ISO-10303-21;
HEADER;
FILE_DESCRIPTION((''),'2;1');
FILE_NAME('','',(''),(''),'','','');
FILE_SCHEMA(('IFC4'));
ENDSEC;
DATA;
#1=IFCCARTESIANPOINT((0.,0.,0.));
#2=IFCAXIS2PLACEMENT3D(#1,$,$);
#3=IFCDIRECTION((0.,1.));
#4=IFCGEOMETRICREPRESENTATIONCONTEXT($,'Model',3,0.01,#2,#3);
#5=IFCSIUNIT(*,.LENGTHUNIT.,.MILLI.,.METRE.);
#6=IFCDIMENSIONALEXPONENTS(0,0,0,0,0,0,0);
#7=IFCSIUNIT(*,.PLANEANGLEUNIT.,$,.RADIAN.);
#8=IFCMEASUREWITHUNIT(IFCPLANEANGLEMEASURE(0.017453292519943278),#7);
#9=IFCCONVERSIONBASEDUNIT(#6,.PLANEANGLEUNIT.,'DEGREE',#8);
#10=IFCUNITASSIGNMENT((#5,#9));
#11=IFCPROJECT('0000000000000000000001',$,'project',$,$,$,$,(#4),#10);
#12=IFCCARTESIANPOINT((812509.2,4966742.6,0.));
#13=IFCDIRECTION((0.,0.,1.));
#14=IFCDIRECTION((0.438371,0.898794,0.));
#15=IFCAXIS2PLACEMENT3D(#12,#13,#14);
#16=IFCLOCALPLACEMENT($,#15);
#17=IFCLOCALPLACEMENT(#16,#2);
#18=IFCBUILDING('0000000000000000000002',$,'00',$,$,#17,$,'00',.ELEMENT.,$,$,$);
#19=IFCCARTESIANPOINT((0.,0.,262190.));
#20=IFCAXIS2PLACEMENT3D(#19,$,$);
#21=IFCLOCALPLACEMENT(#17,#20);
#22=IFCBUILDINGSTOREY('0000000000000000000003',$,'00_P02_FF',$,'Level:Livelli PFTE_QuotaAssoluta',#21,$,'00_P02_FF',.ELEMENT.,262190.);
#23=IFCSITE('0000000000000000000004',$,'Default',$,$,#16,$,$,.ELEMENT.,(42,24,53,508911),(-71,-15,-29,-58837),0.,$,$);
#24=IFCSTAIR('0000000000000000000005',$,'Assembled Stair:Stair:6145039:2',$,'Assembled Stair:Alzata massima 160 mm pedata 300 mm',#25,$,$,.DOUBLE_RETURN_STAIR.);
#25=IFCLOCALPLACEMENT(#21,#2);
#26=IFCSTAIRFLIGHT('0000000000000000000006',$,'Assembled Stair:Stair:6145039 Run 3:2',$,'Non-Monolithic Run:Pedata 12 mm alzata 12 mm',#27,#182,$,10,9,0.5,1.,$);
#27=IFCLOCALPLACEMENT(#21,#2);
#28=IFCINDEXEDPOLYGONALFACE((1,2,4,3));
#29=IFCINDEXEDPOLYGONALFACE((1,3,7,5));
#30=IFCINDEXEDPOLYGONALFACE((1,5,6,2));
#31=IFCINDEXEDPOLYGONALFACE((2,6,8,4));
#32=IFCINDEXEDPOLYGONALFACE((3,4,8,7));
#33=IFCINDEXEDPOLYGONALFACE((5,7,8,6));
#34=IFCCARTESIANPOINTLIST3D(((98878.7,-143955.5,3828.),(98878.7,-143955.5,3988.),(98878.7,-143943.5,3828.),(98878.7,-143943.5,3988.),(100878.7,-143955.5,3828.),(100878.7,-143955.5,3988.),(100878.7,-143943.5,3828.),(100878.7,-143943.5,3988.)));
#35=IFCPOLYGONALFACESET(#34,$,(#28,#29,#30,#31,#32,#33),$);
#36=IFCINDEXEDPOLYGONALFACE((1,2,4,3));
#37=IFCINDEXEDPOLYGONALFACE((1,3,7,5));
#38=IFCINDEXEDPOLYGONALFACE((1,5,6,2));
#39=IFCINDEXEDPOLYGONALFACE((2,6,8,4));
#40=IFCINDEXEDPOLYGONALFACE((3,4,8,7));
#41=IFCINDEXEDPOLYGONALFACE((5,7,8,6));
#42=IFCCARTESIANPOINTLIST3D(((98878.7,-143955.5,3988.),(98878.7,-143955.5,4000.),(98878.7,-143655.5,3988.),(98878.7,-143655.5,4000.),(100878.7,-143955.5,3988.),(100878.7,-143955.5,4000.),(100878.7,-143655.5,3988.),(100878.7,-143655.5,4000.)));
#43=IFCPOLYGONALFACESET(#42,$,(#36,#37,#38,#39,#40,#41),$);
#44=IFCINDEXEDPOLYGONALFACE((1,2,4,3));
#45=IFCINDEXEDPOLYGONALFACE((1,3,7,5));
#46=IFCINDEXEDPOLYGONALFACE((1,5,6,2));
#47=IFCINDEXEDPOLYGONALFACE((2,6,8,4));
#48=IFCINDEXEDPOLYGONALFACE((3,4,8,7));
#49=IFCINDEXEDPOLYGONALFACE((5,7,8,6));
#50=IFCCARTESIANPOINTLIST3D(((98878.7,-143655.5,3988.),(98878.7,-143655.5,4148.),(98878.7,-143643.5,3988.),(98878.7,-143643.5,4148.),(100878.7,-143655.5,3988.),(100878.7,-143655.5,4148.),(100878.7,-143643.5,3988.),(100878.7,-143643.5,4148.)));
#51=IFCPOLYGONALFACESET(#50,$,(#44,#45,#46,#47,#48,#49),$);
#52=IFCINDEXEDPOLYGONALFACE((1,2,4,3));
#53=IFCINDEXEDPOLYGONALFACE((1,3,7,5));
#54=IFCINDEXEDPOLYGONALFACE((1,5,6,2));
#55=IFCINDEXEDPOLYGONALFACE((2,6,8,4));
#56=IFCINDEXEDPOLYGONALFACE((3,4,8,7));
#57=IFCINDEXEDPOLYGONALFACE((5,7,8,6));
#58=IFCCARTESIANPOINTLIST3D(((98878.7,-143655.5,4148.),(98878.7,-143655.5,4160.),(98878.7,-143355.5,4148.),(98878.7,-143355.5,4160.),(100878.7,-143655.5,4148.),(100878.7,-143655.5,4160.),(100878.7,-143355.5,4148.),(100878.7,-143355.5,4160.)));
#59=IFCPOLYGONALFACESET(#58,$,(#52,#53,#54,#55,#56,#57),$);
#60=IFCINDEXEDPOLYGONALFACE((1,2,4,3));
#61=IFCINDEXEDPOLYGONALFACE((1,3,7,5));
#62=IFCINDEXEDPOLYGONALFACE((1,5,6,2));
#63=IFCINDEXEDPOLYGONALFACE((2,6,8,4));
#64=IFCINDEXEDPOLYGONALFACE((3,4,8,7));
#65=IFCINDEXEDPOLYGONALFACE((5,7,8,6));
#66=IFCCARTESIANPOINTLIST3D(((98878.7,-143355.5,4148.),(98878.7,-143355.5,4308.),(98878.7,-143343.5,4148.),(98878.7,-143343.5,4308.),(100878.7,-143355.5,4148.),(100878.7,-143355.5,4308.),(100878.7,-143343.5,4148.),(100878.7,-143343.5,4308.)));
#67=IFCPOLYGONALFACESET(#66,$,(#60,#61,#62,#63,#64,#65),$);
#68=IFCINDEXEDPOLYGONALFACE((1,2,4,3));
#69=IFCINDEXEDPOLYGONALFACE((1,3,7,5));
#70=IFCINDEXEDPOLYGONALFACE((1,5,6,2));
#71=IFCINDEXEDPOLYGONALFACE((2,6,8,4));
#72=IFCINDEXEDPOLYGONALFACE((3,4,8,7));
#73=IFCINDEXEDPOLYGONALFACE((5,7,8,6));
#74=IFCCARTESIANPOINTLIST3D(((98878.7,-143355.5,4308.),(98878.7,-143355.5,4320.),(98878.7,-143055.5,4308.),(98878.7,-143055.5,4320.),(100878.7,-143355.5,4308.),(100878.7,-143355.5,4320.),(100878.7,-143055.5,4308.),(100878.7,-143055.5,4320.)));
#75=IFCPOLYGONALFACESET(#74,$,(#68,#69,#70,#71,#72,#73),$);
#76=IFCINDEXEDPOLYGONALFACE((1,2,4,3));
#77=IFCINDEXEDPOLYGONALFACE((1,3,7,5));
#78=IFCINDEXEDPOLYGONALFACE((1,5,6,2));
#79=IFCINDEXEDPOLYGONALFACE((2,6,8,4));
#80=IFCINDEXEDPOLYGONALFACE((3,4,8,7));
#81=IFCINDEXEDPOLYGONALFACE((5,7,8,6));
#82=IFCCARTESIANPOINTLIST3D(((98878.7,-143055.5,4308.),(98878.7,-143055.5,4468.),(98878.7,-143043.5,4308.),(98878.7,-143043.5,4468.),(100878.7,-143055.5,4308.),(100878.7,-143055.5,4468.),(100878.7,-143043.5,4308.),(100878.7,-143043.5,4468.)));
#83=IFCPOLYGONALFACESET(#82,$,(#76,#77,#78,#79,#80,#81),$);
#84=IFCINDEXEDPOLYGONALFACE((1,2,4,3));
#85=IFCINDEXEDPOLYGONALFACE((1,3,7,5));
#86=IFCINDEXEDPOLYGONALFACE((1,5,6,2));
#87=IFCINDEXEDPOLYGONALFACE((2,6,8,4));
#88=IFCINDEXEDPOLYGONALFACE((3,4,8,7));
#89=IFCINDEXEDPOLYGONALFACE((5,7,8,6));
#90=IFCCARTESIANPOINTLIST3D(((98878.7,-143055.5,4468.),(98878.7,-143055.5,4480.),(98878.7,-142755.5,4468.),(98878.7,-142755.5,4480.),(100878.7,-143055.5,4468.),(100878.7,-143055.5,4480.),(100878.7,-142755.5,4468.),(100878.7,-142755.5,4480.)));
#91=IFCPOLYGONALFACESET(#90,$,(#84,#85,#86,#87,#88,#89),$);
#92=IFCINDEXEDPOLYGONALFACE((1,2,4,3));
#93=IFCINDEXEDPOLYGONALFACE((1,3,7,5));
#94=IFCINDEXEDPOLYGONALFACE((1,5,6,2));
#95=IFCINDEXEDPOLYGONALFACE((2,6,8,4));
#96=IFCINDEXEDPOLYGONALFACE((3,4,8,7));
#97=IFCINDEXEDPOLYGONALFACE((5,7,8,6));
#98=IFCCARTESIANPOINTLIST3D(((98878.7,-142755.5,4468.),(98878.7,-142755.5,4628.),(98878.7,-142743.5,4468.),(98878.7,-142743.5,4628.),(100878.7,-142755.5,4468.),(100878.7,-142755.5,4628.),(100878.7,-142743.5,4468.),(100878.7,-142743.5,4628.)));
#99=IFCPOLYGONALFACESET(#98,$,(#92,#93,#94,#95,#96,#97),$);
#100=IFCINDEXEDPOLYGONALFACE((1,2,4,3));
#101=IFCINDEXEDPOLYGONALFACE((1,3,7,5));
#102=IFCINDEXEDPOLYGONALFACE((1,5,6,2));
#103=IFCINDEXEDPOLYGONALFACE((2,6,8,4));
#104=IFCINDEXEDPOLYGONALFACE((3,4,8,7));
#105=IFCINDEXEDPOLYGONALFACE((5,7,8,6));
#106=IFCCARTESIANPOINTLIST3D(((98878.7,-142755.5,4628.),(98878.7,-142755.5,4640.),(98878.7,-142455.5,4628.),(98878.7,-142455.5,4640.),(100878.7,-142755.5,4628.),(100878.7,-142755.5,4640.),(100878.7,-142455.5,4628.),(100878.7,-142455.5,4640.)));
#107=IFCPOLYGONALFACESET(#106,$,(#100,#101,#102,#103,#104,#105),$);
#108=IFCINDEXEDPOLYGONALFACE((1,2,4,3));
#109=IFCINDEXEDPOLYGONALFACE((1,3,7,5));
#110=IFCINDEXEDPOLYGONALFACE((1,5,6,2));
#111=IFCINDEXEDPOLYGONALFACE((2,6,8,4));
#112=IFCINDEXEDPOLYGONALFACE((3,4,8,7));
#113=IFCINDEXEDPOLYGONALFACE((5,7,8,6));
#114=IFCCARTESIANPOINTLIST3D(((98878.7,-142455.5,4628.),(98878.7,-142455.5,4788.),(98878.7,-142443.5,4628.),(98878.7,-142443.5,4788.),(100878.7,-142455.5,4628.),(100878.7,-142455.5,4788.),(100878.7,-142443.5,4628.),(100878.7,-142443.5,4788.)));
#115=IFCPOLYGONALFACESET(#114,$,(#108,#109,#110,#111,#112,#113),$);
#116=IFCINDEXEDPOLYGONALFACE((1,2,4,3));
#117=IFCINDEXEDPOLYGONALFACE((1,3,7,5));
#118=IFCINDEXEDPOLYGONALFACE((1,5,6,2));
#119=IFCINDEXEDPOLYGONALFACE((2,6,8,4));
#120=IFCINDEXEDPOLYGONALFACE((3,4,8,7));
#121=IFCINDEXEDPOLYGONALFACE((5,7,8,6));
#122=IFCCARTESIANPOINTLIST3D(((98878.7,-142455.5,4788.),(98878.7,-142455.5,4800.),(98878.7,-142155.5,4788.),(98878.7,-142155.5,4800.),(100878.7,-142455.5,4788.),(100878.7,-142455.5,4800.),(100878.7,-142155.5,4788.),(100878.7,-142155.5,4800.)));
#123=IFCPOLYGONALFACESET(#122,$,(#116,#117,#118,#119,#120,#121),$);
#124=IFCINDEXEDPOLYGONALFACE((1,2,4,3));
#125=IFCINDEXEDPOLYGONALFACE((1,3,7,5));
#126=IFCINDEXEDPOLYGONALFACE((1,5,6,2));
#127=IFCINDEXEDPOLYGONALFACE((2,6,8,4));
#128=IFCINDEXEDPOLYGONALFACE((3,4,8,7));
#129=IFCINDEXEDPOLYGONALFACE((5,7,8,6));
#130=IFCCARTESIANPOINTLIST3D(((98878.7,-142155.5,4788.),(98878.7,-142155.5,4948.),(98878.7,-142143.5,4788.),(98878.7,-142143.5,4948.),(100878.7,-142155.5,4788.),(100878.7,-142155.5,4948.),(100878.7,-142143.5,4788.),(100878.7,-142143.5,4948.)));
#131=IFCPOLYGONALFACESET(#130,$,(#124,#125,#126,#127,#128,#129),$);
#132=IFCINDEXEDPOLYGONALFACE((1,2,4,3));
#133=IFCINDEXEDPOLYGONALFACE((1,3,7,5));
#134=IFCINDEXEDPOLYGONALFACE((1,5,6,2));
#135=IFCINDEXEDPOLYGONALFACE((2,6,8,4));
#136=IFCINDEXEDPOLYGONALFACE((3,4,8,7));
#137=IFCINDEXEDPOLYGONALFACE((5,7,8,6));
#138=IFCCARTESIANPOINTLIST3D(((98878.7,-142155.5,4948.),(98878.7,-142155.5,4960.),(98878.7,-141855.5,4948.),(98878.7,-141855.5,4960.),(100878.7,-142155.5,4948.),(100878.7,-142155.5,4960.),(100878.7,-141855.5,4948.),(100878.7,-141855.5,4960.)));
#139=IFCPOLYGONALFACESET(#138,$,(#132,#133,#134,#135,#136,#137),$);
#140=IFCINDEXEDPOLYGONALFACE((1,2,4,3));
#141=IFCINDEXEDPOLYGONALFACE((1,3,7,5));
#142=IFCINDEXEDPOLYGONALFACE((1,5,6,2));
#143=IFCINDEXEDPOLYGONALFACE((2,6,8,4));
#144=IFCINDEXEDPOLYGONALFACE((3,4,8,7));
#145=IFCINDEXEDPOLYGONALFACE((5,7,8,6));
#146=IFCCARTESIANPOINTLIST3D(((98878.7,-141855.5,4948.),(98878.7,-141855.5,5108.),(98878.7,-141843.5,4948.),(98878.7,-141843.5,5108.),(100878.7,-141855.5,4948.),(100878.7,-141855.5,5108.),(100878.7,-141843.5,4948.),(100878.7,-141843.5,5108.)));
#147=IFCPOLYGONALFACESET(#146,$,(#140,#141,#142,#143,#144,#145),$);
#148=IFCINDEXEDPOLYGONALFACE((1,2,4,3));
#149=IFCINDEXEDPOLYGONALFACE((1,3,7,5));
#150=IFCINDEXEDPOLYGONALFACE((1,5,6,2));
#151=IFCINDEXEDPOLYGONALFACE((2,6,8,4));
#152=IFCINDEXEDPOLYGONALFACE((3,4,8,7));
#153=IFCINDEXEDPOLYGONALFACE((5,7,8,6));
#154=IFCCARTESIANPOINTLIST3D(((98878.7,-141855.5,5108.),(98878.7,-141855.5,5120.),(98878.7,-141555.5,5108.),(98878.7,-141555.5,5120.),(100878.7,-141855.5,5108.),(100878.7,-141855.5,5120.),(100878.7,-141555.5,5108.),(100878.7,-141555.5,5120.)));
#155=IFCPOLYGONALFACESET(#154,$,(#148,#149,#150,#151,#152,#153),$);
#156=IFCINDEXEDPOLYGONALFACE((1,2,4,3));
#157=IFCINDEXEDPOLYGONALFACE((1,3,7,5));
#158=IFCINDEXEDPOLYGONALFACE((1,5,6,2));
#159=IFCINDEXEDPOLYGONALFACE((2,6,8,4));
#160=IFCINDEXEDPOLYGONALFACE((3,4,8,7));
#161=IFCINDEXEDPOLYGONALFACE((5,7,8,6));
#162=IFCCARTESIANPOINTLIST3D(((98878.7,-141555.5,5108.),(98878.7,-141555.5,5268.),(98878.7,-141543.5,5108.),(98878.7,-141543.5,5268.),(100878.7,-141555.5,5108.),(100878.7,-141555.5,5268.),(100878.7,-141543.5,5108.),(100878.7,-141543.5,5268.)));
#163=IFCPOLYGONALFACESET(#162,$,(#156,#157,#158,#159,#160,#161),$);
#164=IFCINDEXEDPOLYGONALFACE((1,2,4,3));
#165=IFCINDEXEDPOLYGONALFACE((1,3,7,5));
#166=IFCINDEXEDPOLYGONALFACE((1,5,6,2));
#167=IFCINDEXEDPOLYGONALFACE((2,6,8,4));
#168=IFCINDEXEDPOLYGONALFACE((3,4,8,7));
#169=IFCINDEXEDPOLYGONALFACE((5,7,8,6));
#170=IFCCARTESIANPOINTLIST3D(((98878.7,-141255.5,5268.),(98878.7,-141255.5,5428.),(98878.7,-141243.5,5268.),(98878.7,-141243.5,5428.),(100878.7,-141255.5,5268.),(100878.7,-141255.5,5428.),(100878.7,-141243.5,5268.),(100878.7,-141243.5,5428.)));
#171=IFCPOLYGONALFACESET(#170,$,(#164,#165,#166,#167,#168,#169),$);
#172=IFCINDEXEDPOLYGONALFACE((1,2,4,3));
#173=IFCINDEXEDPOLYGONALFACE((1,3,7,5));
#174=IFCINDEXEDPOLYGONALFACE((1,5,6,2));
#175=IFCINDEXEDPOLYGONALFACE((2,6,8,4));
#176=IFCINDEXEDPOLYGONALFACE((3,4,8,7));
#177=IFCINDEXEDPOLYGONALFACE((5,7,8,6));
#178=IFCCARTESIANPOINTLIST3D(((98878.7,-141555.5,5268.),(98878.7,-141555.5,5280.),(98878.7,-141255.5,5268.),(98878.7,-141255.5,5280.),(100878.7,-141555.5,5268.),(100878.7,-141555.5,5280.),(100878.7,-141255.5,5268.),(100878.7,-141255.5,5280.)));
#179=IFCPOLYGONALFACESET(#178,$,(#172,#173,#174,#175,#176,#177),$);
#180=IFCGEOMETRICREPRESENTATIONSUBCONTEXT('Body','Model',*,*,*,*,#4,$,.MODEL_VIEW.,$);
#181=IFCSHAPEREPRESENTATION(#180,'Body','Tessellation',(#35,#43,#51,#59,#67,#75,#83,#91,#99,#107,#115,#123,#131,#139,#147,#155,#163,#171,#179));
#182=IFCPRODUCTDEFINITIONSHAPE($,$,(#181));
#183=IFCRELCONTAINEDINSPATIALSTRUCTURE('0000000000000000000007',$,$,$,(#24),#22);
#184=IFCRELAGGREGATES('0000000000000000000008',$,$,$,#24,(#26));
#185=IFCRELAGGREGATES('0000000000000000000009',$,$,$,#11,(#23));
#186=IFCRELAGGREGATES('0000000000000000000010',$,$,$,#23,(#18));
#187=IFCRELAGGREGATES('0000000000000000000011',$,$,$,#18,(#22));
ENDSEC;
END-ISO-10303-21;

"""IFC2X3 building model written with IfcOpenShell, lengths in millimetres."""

from ifc_helpers import new_model, entity, si_unit, converted_unit, direction, frame, origin, origin_2d_with_axis, place, context, subcontext, project, spatial, rectangle, extrude, element, aggregate, save


model = new_model("IFC2X3")

# Units and contexts
model_context = context("Model", 3, precision=0.01, world=origin(), true_north=direction((0.0, 1.0)))
body_context = subcontext(model_context, "Body", "Model", "MODEL_VIEW")
ifc_project = project(units=[si_unit("LENGTHUNIT", "METRE", prefix="MILLI"), converted_unit("PLANEANGLEUNIT", "DEGREE", entity("IfcPlaneAngleMeasure", 0.017453292519943278), si_unit("PLANEANGLEUNIT", "RADIAN"), dimensions=[0, 0, 0, 0, 0, 0, 0])], contexts=[model_context])

# Site, building, storey
site_placement = place(None, frame((812509.2, 4966742.6, 0.0), z_axis=(0.0, 0.0, 1.0), x_axis=(0.438371, 0.898794, 0.0)))
site = spatial("IfcSite", under=ifc_project, at=site_placement, Name="Default", CompositionType="ELEMENT", RefLatitude=(42, 24, 53, 508911), RefLongitude=(-71, -15, -29, -58837), RefElevation=0.0)
building_placement = place(site_placement, origin())
building = spatial("IfcBuilding", under=site, at=building_placement, Name="00", LongName="00", CompositionType="ELEMENT")
storey_placement = place(building_placement, frame((0.0, 0.0, 262190.0)))
storey = spatial("IfcBuildingStorey", under=building, at=storey_placement, Name="00_P02_FF", ObjectType="Level:Livelli PFTE_QuotaAssoluta", LongName="00_P02_FF", CompositionType="ELEMENT", Elevation=262190.0)

# Stair
stair_1_placement = place(storey_placement, origin())
stair_1 = element("IfcStair", 1, at=stair_1_placement, inside=storey, Name="Assembled Stair:Stair:6145039:2", ObjectType="Assembled Stair:Alzata massima 160 mm pedata 300 mm", ShapeType="DOUBLE_RETURN_STAIR")

# Stair flight
stair_flight_1_placement = place(stair_1_placement, origin())
stair_flight_1 = element("IfcStairFlight", 2, at=stair_flight_1_placement, Name="Assembled Stair:Stair:6145039 Run 3:2", ObjectType="Non-Monolithic Run:Pedata 12 mm alzata 12 mm", NumberOfRiser=10, NumberOfTreads=9, RiserHeight=0.5, TreadLength=1.0, context=body_context, shape_type="SweptSolid", body=[
    extrude(rectangle(XDim=2000.0, YDim=12.0, at=origin_2d_with_axis()), frame((99878.7, -143949.5, 3828.0), z_axis=(0.0, 0.0, 1.0), x_axis=(-1.0, 0.0, 0.0)), (0.0, 0.0, 1.0), 160.0),
    extrude(rectangle(XDim=300.0, YDim=2000.0, at=origin_2d_with_axis()), frame((99878.7, -143805.5, 3988.0), z_axis=(0.0, 0.0, 1.0), x_axis=(0.0, -1.0, 0.0)), (0.0, 0.0, 1.0), 12.0),
    extrude(rectangle(XDim=2000.0, YDim=12.0, at=origin_2d_with_axis()), frame((99878.7, -143649.5, 3988.0), z_axis=(0.0, 0.0, 1.0), x_axis=(-1.0, 0.0, 0.0)), (0.0, 0.0, 1.0), 160.0),
    extrude(rectangle(XDim=300.0, YDim=2000.0, at=origin_2d_with_axis()), frame((99878.7, -143505.5, 4148.0), z_axis=(0.0, 0.0, 1.0), x_axis=(0.0, -1.0, 0.0)), (0.0, 0.0, 1.0), 12.0),
    extrude(rectangle(XDim=2000.0, YDim=12.0, at=origin_2d_with_axis()), frame((99878.7, -143349.5, 4148.0), z_axis=(0.0, 0.0, 1.0), x_axis=(-1.0, 0.0, 0.0)), (0.0, 0.0, 1.0), 160.0),
    extrude(rectangle(XDim=300.0, YDim=2000.0, at=origin_2d_with_axis()), frame((99878.7, -143205.5, 4308.0), z_axis=(0.0, 0.0, 1.0), x_axis=(0.0, -1.0, 0.0)), (0.0, 0.0, 1.0), 12.0),
    extrude(rectangle(XDim=2000.0, YDim=12.0, at=origin_2d_with_axis()), frame((99878.7, -143049.5, 4308.0), z_axis=(0.0, 0.0, 1.0), x_axis=(-1.0, 0.0, 0.0)), (0.0, 0.0, 1.0), 160.0),
    extrude(rectangle(XDim=300.0, YDim=2000.0, at=origin_2d_with_axis()), frame((99878.7, -142905.5, 4468.0), z_axis=(0.0, 0.0, 1.0), x_axis=(0.0, -1.0, 0.0)), (0.0, 0.0, 1.0), 12.0),
    extrude(rectangle(XDim=2000.0, YDim=12.0, at=origin_2d_with_axis()), frame((99878.7, -142749.5, 4468.0), z_axis=(0.0, 0.0, 1.0), x_axis=(-1.0, 0.0, 0.0)), (0.0, 0.0, 1.0), 160.0),
    extrude(rectangle(XDim=300.0, YDim=2000.0, at=origin_2d_with_axis()), frame((99878.7, -142605.5, 4628.0), z_axis=(0.0, 0.0, 1.0), x_axis=(0.0, -1.0, 0.0)), (0.0, 0.0, 1.0), 12.0),
    extrude(rectangle(XDim=2000.0, YDim=12.0, at=origin_2d_with_axis()), frame((99878.7, -142449.5, 4628.0), z_axis=(0.0, 0.0, 1.0), x_axis=(-1.0, 0.0, 0.0)), (0.0, 0.0, 1.0), 160.0),
    extrude(rectangle(XDim=300.0, YDim=2000.0, at=origin_2d_with_axis()), frame((99878.7, -142305.5, 4788.0), z_axis=(0.0, 0.0, 1.0), x_axis=(0.0, -1.0, 0.0)), (0.0, 0.0, 1.0), 12.0),
    extrude(rectangle(XDim=2000.0, YDim=12.0, at=origin_2d_with_axis()), frame((99878.7, -142149.5, 4788.0), z_axis=(0.0, 0.0, 1.0), x_axis=(-1.0, 0.0, 0.0)), (0.0, 0.0, 1.0), 160.0),
    extrude(rectangle(XDim=300.0, YDim=2000.0, at=origin_2d_with_axis()), frame((99878.7, -142005.5, 4948.0), z_axis=(0.0, 0.0, 1.0), x_axis=(0.0, -1.0, 0.0)), (0.0, 0.0, 1.0), 12.0),
    extrude(rectangle(XDim=2000.0, YDim=12.0, at=origin_2d_with_axis()), frame((99878.7, -141849.5, 4948.0), z_axis=(0.0, 0.0, 1.0), x_axis=(-1.0, 0.0, 0.0)), (0.0, 0.0, 1.0), 160.0),
    extrude(rectangle(XDim=300.0, YDim=2000.0, at=origin_2d_with_axis()), frame((99878.7, -141705.5, 5108.0), z_axis=(0.0, 0.0, 1.0), x_axis=(0.0, -1.0, 0.0)), (0.0, 0.0, 1.0), 12.0),
    extrude(rectangle(XDim=2000.0, YDim=12.0, at=origin_2d_with_axis()), frame((99878.7, -141549.5, 5108.0), z_axis=(0.0, 0.0, 1.0), x_axis=(-1.0, 0.0, 0.0)), (0.0, 0.0, 1.0), 160.0),
    extrude(rectangle(XDim=2000.0, YDim=12.0, at=origin_2d_with_axis()), frame((99878.7, -141249.5, 5268.0), z_axis=(0.0, 0.0, 1.0), x_axis=(-1.0, 0.0, 0.0)), (0.0, 0.0, 1.0), 160.0),
    extrude(rectangle(XDim=300.0, YDim=2000.0, at=origin_2d_with_axis()), frame((99878.7, -141405.5, 5268.0), z_axis=(0.0, 0.0, 1.0), x_axis=(0.0, -1.0, 0.0)), (0.0, 0.0, 1.0), 12.0),
])
aggregate(stair_1, [stair_flight_1])

save(model, "model.ifc")
